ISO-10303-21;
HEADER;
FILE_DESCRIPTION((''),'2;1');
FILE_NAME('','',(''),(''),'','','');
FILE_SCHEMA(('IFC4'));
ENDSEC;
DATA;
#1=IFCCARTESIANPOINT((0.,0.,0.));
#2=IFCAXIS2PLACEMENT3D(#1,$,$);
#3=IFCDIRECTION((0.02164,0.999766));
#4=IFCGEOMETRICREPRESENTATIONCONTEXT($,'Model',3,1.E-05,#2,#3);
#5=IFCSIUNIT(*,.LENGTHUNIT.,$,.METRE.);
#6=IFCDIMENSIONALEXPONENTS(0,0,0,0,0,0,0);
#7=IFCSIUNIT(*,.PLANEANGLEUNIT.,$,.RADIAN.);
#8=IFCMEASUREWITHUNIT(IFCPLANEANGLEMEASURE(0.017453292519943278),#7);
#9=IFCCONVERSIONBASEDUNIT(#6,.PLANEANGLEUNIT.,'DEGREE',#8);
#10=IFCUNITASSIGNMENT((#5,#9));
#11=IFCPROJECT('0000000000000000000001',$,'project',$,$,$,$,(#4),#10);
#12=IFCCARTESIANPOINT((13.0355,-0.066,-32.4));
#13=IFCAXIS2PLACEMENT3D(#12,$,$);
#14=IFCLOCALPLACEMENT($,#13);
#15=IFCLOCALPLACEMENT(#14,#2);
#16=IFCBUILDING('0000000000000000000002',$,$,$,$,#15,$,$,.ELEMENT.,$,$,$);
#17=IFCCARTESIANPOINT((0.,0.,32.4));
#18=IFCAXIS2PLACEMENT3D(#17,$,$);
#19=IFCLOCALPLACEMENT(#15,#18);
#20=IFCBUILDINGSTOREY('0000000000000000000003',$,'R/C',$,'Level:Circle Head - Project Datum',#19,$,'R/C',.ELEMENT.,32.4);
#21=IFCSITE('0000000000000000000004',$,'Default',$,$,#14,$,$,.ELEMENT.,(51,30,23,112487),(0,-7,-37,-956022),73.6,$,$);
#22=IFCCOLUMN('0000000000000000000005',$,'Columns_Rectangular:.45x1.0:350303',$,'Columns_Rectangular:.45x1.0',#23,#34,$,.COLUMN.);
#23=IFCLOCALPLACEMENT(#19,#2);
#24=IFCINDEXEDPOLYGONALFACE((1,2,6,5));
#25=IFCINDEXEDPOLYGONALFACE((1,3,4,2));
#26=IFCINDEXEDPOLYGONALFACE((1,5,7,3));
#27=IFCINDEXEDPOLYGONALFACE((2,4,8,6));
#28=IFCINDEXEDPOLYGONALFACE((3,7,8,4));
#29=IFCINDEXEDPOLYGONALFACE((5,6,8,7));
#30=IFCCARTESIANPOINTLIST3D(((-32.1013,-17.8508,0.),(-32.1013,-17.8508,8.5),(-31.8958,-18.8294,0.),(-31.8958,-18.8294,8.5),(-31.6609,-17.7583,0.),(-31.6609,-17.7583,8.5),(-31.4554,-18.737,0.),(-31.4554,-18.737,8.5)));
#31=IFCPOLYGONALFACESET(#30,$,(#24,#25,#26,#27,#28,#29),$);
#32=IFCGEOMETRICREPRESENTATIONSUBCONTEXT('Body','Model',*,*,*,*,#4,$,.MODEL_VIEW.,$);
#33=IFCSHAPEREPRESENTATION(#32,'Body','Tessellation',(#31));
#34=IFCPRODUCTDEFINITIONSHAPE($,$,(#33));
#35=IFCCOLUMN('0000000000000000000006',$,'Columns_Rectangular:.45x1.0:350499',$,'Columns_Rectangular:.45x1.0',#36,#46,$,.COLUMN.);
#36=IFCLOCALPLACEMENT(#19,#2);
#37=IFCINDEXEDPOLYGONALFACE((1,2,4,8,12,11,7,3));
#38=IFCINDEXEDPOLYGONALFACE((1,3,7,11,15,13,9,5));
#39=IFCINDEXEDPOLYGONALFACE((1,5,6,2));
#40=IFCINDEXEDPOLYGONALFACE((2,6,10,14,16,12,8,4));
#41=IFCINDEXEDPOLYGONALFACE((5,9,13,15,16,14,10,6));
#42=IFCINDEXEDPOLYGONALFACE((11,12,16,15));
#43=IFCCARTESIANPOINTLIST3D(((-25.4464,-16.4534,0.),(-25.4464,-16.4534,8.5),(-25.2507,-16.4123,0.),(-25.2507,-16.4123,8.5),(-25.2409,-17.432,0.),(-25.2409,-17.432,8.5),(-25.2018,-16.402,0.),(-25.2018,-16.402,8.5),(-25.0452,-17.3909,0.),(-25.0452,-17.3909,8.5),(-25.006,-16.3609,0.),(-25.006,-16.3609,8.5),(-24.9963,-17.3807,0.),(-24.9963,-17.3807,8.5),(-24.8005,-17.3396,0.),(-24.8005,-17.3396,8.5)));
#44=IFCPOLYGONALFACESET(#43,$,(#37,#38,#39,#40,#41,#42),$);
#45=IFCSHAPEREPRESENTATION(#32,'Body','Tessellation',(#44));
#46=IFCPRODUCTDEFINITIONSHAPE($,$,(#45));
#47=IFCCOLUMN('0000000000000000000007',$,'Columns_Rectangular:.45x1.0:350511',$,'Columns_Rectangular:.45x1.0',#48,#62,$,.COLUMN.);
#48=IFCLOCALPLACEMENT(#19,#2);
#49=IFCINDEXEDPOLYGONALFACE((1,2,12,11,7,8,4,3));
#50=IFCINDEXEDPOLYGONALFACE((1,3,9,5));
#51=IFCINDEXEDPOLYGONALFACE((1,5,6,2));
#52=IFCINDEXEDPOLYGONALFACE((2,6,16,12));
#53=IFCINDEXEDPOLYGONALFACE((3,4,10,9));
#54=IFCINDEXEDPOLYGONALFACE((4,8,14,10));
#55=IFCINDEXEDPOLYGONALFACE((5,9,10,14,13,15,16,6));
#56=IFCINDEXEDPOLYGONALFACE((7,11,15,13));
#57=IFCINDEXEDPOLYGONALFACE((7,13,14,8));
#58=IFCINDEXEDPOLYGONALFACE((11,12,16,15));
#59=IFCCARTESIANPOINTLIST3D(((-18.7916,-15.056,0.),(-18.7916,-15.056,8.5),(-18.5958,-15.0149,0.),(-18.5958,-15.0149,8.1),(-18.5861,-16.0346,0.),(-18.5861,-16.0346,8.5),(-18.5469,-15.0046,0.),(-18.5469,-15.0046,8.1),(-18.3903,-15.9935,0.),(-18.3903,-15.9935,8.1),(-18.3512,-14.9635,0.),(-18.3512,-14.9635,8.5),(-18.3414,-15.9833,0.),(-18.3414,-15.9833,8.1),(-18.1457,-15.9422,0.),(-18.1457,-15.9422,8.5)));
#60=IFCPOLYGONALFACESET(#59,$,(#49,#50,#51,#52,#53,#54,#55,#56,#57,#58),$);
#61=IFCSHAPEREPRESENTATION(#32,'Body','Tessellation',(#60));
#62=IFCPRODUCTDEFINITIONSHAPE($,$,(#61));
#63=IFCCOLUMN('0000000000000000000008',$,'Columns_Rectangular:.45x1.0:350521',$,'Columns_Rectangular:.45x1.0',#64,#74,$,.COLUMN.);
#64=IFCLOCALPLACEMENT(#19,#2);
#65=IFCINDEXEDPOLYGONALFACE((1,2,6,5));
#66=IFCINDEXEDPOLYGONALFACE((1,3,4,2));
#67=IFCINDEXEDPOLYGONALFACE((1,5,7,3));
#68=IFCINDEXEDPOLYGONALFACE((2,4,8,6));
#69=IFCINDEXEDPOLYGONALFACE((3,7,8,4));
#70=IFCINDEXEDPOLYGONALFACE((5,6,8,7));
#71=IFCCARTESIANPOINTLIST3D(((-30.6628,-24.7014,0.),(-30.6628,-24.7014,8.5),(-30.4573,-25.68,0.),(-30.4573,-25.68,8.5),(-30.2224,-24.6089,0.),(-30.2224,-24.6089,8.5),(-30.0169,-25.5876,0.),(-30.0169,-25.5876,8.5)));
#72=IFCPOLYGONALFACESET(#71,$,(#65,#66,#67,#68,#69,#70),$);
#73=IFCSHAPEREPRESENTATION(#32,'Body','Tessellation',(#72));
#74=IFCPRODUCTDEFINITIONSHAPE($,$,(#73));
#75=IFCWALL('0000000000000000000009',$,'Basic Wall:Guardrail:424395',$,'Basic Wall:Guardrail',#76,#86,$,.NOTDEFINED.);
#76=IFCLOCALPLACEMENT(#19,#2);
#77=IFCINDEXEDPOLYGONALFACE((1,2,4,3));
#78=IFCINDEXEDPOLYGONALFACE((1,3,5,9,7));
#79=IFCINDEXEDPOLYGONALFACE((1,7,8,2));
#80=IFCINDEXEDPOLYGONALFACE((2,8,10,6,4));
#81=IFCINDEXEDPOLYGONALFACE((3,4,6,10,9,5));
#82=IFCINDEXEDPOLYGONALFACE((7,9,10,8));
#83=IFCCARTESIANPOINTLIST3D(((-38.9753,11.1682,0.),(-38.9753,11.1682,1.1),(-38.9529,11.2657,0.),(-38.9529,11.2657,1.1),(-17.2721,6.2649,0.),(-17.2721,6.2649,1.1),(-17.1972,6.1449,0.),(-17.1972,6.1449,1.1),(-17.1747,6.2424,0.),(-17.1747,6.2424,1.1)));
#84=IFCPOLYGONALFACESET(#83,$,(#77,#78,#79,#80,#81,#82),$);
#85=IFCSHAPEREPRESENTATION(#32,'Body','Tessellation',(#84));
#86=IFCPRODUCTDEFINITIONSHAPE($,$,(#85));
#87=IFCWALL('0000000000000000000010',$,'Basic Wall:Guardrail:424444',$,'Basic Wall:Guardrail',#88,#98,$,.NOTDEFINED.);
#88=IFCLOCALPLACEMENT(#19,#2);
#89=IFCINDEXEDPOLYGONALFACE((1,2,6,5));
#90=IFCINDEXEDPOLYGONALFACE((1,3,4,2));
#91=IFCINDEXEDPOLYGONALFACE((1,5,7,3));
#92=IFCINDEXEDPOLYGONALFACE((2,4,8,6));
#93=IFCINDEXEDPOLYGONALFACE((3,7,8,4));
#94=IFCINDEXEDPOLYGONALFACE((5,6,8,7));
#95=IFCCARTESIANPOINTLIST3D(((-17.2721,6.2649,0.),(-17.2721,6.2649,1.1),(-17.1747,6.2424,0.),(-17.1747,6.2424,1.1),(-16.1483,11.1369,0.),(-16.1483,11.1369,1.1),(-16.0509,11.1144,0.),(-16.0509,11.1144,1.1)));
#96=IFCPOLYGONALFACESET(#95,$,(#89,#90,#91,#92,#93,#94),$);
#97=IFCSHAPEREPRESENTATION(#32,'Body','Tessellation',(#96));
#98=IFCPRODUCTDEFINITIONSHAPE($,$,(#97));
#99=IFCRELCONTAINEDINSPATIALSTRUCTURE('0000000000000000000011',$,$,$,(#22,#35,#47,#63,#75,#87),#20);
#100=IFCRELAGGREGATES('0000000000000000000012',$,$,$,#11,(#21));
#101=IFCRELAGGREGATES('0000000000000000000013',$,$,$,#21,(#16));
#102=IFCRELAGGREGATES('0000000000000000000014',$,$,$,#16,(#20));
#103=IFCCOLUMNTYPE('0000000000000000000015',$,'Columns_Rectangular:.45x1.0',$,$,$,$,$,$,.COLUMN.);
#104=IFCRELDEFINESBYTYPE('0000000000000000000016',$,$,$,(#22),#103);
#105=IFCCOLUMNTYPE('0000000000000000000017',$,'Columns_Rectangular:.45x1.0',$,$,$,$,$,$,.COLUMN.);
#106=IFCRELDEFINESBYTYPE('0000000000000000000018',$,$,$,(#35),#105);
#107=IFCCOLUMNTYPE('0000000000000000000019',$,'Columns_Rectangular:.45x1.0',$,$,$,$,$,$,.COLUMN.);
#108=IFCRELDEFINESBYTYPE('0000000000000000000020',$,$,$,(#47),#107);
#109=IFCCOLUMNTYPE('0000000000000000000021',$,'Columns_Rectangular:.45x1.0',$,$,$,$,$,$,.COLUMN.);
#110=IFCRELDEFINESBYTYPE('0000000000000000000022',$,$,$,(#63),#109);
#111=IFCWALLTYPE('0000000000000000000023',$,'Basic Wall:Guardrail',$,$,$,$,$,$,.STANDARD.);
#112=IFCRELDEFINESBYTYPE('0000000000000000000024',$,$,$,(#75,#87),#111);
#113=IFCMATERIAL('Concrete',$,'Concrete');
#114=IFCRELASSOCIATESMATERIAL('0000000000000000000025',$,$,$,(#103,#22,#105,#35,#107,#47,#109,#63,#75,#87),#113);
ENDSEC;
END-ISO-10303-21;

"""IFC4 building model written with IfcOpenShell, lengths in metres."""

from ifc_helpers import new_model, entity, si_unit, converted_unit, direction, frame, origin, place, context, subcontext, project, spatial, indexed_curve, outline, extrude, source, transform, mapped, material, type_object, type_shapes, element, save


model = new_model("IFC4")

# Units and contexts
model_context = context("Model", 3, precision=1e-05, world=origin(), true_north=direction((0.02164, 0.999766)))
body_context = subcontext(model_context, "Body", "Model", "MODEL_VIEW")
ifc_project = project(units=[si_unit("LENGTHUNIT", "METRE"), converted_unit("PLANEANGLEUNIT", "DEGREE", entity("IfcPlaneAngleMeasure", 0.017453292519943278), si_unit("PLANEANGLEUNIT", "RADIAN"), dimensions=[0, 0, 0, 0, 0, 0, 0])], contexts=[model_context])

# Site, building, storey
site_placement = place(None, frame((13.0355, -0.066, -32.4)))
site = spatial("IfcSite", under=ifc_project, at=site_placement, Name="Default", CompositionType="ELEMENT", RefLatitude=(51, 30, 23, 112487), RefLongitude=(0, -7, -37, -956022), RefElevation=73.6)
building_placement = place(site_placement, origin())
building = spatial("IfcBuilding", under=site, at=building_placement, CompositionType="ELEMENT")
storey_placement = place(building_placement, frame((0.0, 0.0, 32.4)))
storey = spatial("IfcBuildingStorey", under=building, at=storey_placement, Name="R/C", ObjectType="Level:Circle Head - Project Datum", LongName="R/C", CompositionType="ELEMENT", Elevation=32.4)

# Columns
ifc_material = material(Name="Concrete", Category="Concrete")
column_type_1 = type_object("IfcColumnType", Name="Columns_Rectangular:.45x1.0", PredefinedType="COLUMN", material=ifc_material)
shared_shape_1 = source(origin(), body_context, "Body", "SweptSolid", [
    extrude(outline(indexed_curve([(-0.5, -0.225), (0.5, -0.225), (0.5, 0.225), (-0.5, 0.225), (-0.5, -0.225)], self_intersect=False)), frame((-31.7784, -18.2939, 32.4), z_axis=(0.0, 0.0, 1.0), x_axis=(-0.2055, 0.978657, 0.0)), (0.0, 0.0, 1.0), 8.5),
])
type_shapes(column_type_1, [shared_shape_1])
column_1_placement = place(storey_placement, frame((0.0, 0.0, -32.4)))
element("IfcColumn", 1, at=column_1_placement, inside=storey, type_object=column_type_1, material=ifc_material, Name="Columns_Rectangular:.45x1.0:350303", ObjectType="Columns_Rectangular:.45x1.0", PredefinedType="COLUMN", context=body_context, shape_type="MappedRepresentation", body=[
    mapped(shared_shape_1, transform((0.0, 0.0, 0.0), scale=1.0)),
])
column_type_2 = type_object("IfcColumnType", Name="Columns_Rectangular:.45x1.0", PredefinedType="COLUMN", material=ifc_material)
shared_shape_2 = source(origin(), body_context, "Body", "SweptSolid", [
    extrude(outline(indexed_curve([(-0.225, -0.5), (-0.025, -0.5), (0.025, -0.5), (0.225, -0.5), (0.225, 0.5), (0.025, 0.5), (-0.025, 0.5), (-0.225, 0.5), (-0.225, -0.5)], self_intersect=False)), frame((-25.1235, -16.8965, 32.4), z_axis=(0.0, 0.0, 1.0), x_axis=(0.978657, 0.2055, 0.0)), (0.0, 0.0, 1.0), 8.5),
])
type_shapes(column_type_2, [shared_shape_2])
column_2_placement = place(storey_placement, frame((0.0, 0.0, -32.4)))
element("IfcColumn", 2, at=column_2_placement, inside=storey, type_object=column_type_2, material=ifc_material, Name="Columns_Rectangular:.45x1.0:350499", ObjectType="Columns_Rectangular:.45x1.0", PredefinedType="COLUMN", context=body_context, shape_type="MappedRepresentation", body=[
    mapped(shared_shape_2, transform((0.0, 0.0, 0.0), scale=1.0)),
])
column_type_3 = type_object("IfcColumnType", Name="Columns_Rectangular:.45x1.0", PredefinedType="COLUMN", material=ifc_material)
shared_shape_3 = source(origin(), body_context, "Body", "SweptSolid", [
    extrude(outline(indexed_curve([(-4.35, -0.225), (4.15, -0.225), (4.15, -0.025), (-3.95, -0.025), (-3.95, 0.025), (4.15, 0.025), (4.15, 0.225), (-4.35, 0.225), (-4.35, -0.225)], self_intersect=False)), frame((-18.3659, -15.9884, 36.55), z_axis=(-0.2055, 0.978657, 0.0), x_axis=(0.0, 0.0, -1.0)), (0.0, 0.0, 1.0), 1.0),
])
type_shapes(column_type_3, [shared_shape_3])
column_3_placement = place(storey_placement, frame((0.0, 0.0, -32.4)))
element("IfcColumn", 3, at=column_3_placement, inside=storey, type_object=column_type_3, material=ifc_material, Name="Columns_Rectangular:.45x1.0:350511", ObjectType="Columns_Rectangular:.45x1.0", PredefinedType="COLUMN", context=body_context, shape_type="MappedRepresentation", body=[
    mapped(shared_shape_3, transform((0.0, 0.0, 0.0), scale=1.0)),
])
column_type_4 = type_object("IfcColumnType", Name="Columns_Rectangular:.45x1.0", PredefinedType="COLUMN", material=ifc_material)
shared_shape_4 = source(origin(), body_context, "Body", "SweptSolid", [
    extrude(outline(indexed_curve([(-0.5, -0.225), (0.5, -0.225), (0.5, 0.225), (-0.5, 0.225), (-0.5, -0.225)], self_intersect=False)), frame((-30.3399, -25.1445, 32.4), z_axis=(0.0, 0.0, 1.0), x_axis=(-0.2055, 0.978657, 0.0)), (0.0, 0.0, 1.0), 8.5),
])
type_shapes(column_type_4, [shared_shape_4])
column_4_placement = place(storey_placement, frame((0.0, 0.0, -32.4)))
element("IfcColumn", 4, at=column_4_placement, inside=storey, type_object=column_type_4, material=ifc_material, Name="Columns_Rectangular:.45x1.0:350521", ObjectType="Columns_Rectangular:.45x1.0", PredefinedType="COLUMN", context=body_context, shape_type="MappedRepresentation", body=[
    mapped(shared_shape_4, transform((0.0, 0.0, 0.0), scale=1.0)),
])

# Walls
wall_type = type_object("IfcWallType", Name="Basic Wall:Guardrail", PredefinedType="STANDARD")
wall_1_placement = place(storey_placement, frame((-38.9641, 11.217, 0.0), z_axis=(0.0, 0.0, 1.0), x_axis=(0.974415, -0.224757, 0.0)))
element("IfcWall", 5, at=wall_1_placement, inside=storey, type_object=wall_type, material=ifc_material, Name="Basic Wall:Guardrail:424395", ObjectType="Basic Wall:Guardrail", PredefinedType="NOTDEFINED", context=body_context, shape_type="SweptSolid", body=[
    extrude(outline(indexed_curve([(22.35, -0.05), (22.35, 0.05), (22.25, 0.05), (0.0, 0.05), (0.0, -0.05), (22.35, -0.05)], self_intersect=False)), origin(), (0.0, 0.0, 1.0), 1.1),
])
wall_2_placement = place(storey_placement, frame((-17.2234, 6.2536, 0.0), z_axis=(0.0, 0.0, 1.0), x_axis=(0.224757, 0.974415, 0.0)))
element("IfcWall", 6, at=wall_2_placement, inside=storey, type_object=wall_type, material=ifc_material, Name="Basic Wall:Guardrail:424444", ObjectType="Basic Wall:Guardrail", PredefinedType="NOTDEFINED", context=body_context, shape_type="SweptSolid", body=[
    extrude(outline(indexed_curve([(5.0, -0.05), (5.0, 0.05), (0.0, 0.05), (0.0, -0.05), (5.0, -0.05)], self_intersect=False)), origin(), (0.0, 0.0, 1.0), 1.1),
])

save(model, "model.ifc")
